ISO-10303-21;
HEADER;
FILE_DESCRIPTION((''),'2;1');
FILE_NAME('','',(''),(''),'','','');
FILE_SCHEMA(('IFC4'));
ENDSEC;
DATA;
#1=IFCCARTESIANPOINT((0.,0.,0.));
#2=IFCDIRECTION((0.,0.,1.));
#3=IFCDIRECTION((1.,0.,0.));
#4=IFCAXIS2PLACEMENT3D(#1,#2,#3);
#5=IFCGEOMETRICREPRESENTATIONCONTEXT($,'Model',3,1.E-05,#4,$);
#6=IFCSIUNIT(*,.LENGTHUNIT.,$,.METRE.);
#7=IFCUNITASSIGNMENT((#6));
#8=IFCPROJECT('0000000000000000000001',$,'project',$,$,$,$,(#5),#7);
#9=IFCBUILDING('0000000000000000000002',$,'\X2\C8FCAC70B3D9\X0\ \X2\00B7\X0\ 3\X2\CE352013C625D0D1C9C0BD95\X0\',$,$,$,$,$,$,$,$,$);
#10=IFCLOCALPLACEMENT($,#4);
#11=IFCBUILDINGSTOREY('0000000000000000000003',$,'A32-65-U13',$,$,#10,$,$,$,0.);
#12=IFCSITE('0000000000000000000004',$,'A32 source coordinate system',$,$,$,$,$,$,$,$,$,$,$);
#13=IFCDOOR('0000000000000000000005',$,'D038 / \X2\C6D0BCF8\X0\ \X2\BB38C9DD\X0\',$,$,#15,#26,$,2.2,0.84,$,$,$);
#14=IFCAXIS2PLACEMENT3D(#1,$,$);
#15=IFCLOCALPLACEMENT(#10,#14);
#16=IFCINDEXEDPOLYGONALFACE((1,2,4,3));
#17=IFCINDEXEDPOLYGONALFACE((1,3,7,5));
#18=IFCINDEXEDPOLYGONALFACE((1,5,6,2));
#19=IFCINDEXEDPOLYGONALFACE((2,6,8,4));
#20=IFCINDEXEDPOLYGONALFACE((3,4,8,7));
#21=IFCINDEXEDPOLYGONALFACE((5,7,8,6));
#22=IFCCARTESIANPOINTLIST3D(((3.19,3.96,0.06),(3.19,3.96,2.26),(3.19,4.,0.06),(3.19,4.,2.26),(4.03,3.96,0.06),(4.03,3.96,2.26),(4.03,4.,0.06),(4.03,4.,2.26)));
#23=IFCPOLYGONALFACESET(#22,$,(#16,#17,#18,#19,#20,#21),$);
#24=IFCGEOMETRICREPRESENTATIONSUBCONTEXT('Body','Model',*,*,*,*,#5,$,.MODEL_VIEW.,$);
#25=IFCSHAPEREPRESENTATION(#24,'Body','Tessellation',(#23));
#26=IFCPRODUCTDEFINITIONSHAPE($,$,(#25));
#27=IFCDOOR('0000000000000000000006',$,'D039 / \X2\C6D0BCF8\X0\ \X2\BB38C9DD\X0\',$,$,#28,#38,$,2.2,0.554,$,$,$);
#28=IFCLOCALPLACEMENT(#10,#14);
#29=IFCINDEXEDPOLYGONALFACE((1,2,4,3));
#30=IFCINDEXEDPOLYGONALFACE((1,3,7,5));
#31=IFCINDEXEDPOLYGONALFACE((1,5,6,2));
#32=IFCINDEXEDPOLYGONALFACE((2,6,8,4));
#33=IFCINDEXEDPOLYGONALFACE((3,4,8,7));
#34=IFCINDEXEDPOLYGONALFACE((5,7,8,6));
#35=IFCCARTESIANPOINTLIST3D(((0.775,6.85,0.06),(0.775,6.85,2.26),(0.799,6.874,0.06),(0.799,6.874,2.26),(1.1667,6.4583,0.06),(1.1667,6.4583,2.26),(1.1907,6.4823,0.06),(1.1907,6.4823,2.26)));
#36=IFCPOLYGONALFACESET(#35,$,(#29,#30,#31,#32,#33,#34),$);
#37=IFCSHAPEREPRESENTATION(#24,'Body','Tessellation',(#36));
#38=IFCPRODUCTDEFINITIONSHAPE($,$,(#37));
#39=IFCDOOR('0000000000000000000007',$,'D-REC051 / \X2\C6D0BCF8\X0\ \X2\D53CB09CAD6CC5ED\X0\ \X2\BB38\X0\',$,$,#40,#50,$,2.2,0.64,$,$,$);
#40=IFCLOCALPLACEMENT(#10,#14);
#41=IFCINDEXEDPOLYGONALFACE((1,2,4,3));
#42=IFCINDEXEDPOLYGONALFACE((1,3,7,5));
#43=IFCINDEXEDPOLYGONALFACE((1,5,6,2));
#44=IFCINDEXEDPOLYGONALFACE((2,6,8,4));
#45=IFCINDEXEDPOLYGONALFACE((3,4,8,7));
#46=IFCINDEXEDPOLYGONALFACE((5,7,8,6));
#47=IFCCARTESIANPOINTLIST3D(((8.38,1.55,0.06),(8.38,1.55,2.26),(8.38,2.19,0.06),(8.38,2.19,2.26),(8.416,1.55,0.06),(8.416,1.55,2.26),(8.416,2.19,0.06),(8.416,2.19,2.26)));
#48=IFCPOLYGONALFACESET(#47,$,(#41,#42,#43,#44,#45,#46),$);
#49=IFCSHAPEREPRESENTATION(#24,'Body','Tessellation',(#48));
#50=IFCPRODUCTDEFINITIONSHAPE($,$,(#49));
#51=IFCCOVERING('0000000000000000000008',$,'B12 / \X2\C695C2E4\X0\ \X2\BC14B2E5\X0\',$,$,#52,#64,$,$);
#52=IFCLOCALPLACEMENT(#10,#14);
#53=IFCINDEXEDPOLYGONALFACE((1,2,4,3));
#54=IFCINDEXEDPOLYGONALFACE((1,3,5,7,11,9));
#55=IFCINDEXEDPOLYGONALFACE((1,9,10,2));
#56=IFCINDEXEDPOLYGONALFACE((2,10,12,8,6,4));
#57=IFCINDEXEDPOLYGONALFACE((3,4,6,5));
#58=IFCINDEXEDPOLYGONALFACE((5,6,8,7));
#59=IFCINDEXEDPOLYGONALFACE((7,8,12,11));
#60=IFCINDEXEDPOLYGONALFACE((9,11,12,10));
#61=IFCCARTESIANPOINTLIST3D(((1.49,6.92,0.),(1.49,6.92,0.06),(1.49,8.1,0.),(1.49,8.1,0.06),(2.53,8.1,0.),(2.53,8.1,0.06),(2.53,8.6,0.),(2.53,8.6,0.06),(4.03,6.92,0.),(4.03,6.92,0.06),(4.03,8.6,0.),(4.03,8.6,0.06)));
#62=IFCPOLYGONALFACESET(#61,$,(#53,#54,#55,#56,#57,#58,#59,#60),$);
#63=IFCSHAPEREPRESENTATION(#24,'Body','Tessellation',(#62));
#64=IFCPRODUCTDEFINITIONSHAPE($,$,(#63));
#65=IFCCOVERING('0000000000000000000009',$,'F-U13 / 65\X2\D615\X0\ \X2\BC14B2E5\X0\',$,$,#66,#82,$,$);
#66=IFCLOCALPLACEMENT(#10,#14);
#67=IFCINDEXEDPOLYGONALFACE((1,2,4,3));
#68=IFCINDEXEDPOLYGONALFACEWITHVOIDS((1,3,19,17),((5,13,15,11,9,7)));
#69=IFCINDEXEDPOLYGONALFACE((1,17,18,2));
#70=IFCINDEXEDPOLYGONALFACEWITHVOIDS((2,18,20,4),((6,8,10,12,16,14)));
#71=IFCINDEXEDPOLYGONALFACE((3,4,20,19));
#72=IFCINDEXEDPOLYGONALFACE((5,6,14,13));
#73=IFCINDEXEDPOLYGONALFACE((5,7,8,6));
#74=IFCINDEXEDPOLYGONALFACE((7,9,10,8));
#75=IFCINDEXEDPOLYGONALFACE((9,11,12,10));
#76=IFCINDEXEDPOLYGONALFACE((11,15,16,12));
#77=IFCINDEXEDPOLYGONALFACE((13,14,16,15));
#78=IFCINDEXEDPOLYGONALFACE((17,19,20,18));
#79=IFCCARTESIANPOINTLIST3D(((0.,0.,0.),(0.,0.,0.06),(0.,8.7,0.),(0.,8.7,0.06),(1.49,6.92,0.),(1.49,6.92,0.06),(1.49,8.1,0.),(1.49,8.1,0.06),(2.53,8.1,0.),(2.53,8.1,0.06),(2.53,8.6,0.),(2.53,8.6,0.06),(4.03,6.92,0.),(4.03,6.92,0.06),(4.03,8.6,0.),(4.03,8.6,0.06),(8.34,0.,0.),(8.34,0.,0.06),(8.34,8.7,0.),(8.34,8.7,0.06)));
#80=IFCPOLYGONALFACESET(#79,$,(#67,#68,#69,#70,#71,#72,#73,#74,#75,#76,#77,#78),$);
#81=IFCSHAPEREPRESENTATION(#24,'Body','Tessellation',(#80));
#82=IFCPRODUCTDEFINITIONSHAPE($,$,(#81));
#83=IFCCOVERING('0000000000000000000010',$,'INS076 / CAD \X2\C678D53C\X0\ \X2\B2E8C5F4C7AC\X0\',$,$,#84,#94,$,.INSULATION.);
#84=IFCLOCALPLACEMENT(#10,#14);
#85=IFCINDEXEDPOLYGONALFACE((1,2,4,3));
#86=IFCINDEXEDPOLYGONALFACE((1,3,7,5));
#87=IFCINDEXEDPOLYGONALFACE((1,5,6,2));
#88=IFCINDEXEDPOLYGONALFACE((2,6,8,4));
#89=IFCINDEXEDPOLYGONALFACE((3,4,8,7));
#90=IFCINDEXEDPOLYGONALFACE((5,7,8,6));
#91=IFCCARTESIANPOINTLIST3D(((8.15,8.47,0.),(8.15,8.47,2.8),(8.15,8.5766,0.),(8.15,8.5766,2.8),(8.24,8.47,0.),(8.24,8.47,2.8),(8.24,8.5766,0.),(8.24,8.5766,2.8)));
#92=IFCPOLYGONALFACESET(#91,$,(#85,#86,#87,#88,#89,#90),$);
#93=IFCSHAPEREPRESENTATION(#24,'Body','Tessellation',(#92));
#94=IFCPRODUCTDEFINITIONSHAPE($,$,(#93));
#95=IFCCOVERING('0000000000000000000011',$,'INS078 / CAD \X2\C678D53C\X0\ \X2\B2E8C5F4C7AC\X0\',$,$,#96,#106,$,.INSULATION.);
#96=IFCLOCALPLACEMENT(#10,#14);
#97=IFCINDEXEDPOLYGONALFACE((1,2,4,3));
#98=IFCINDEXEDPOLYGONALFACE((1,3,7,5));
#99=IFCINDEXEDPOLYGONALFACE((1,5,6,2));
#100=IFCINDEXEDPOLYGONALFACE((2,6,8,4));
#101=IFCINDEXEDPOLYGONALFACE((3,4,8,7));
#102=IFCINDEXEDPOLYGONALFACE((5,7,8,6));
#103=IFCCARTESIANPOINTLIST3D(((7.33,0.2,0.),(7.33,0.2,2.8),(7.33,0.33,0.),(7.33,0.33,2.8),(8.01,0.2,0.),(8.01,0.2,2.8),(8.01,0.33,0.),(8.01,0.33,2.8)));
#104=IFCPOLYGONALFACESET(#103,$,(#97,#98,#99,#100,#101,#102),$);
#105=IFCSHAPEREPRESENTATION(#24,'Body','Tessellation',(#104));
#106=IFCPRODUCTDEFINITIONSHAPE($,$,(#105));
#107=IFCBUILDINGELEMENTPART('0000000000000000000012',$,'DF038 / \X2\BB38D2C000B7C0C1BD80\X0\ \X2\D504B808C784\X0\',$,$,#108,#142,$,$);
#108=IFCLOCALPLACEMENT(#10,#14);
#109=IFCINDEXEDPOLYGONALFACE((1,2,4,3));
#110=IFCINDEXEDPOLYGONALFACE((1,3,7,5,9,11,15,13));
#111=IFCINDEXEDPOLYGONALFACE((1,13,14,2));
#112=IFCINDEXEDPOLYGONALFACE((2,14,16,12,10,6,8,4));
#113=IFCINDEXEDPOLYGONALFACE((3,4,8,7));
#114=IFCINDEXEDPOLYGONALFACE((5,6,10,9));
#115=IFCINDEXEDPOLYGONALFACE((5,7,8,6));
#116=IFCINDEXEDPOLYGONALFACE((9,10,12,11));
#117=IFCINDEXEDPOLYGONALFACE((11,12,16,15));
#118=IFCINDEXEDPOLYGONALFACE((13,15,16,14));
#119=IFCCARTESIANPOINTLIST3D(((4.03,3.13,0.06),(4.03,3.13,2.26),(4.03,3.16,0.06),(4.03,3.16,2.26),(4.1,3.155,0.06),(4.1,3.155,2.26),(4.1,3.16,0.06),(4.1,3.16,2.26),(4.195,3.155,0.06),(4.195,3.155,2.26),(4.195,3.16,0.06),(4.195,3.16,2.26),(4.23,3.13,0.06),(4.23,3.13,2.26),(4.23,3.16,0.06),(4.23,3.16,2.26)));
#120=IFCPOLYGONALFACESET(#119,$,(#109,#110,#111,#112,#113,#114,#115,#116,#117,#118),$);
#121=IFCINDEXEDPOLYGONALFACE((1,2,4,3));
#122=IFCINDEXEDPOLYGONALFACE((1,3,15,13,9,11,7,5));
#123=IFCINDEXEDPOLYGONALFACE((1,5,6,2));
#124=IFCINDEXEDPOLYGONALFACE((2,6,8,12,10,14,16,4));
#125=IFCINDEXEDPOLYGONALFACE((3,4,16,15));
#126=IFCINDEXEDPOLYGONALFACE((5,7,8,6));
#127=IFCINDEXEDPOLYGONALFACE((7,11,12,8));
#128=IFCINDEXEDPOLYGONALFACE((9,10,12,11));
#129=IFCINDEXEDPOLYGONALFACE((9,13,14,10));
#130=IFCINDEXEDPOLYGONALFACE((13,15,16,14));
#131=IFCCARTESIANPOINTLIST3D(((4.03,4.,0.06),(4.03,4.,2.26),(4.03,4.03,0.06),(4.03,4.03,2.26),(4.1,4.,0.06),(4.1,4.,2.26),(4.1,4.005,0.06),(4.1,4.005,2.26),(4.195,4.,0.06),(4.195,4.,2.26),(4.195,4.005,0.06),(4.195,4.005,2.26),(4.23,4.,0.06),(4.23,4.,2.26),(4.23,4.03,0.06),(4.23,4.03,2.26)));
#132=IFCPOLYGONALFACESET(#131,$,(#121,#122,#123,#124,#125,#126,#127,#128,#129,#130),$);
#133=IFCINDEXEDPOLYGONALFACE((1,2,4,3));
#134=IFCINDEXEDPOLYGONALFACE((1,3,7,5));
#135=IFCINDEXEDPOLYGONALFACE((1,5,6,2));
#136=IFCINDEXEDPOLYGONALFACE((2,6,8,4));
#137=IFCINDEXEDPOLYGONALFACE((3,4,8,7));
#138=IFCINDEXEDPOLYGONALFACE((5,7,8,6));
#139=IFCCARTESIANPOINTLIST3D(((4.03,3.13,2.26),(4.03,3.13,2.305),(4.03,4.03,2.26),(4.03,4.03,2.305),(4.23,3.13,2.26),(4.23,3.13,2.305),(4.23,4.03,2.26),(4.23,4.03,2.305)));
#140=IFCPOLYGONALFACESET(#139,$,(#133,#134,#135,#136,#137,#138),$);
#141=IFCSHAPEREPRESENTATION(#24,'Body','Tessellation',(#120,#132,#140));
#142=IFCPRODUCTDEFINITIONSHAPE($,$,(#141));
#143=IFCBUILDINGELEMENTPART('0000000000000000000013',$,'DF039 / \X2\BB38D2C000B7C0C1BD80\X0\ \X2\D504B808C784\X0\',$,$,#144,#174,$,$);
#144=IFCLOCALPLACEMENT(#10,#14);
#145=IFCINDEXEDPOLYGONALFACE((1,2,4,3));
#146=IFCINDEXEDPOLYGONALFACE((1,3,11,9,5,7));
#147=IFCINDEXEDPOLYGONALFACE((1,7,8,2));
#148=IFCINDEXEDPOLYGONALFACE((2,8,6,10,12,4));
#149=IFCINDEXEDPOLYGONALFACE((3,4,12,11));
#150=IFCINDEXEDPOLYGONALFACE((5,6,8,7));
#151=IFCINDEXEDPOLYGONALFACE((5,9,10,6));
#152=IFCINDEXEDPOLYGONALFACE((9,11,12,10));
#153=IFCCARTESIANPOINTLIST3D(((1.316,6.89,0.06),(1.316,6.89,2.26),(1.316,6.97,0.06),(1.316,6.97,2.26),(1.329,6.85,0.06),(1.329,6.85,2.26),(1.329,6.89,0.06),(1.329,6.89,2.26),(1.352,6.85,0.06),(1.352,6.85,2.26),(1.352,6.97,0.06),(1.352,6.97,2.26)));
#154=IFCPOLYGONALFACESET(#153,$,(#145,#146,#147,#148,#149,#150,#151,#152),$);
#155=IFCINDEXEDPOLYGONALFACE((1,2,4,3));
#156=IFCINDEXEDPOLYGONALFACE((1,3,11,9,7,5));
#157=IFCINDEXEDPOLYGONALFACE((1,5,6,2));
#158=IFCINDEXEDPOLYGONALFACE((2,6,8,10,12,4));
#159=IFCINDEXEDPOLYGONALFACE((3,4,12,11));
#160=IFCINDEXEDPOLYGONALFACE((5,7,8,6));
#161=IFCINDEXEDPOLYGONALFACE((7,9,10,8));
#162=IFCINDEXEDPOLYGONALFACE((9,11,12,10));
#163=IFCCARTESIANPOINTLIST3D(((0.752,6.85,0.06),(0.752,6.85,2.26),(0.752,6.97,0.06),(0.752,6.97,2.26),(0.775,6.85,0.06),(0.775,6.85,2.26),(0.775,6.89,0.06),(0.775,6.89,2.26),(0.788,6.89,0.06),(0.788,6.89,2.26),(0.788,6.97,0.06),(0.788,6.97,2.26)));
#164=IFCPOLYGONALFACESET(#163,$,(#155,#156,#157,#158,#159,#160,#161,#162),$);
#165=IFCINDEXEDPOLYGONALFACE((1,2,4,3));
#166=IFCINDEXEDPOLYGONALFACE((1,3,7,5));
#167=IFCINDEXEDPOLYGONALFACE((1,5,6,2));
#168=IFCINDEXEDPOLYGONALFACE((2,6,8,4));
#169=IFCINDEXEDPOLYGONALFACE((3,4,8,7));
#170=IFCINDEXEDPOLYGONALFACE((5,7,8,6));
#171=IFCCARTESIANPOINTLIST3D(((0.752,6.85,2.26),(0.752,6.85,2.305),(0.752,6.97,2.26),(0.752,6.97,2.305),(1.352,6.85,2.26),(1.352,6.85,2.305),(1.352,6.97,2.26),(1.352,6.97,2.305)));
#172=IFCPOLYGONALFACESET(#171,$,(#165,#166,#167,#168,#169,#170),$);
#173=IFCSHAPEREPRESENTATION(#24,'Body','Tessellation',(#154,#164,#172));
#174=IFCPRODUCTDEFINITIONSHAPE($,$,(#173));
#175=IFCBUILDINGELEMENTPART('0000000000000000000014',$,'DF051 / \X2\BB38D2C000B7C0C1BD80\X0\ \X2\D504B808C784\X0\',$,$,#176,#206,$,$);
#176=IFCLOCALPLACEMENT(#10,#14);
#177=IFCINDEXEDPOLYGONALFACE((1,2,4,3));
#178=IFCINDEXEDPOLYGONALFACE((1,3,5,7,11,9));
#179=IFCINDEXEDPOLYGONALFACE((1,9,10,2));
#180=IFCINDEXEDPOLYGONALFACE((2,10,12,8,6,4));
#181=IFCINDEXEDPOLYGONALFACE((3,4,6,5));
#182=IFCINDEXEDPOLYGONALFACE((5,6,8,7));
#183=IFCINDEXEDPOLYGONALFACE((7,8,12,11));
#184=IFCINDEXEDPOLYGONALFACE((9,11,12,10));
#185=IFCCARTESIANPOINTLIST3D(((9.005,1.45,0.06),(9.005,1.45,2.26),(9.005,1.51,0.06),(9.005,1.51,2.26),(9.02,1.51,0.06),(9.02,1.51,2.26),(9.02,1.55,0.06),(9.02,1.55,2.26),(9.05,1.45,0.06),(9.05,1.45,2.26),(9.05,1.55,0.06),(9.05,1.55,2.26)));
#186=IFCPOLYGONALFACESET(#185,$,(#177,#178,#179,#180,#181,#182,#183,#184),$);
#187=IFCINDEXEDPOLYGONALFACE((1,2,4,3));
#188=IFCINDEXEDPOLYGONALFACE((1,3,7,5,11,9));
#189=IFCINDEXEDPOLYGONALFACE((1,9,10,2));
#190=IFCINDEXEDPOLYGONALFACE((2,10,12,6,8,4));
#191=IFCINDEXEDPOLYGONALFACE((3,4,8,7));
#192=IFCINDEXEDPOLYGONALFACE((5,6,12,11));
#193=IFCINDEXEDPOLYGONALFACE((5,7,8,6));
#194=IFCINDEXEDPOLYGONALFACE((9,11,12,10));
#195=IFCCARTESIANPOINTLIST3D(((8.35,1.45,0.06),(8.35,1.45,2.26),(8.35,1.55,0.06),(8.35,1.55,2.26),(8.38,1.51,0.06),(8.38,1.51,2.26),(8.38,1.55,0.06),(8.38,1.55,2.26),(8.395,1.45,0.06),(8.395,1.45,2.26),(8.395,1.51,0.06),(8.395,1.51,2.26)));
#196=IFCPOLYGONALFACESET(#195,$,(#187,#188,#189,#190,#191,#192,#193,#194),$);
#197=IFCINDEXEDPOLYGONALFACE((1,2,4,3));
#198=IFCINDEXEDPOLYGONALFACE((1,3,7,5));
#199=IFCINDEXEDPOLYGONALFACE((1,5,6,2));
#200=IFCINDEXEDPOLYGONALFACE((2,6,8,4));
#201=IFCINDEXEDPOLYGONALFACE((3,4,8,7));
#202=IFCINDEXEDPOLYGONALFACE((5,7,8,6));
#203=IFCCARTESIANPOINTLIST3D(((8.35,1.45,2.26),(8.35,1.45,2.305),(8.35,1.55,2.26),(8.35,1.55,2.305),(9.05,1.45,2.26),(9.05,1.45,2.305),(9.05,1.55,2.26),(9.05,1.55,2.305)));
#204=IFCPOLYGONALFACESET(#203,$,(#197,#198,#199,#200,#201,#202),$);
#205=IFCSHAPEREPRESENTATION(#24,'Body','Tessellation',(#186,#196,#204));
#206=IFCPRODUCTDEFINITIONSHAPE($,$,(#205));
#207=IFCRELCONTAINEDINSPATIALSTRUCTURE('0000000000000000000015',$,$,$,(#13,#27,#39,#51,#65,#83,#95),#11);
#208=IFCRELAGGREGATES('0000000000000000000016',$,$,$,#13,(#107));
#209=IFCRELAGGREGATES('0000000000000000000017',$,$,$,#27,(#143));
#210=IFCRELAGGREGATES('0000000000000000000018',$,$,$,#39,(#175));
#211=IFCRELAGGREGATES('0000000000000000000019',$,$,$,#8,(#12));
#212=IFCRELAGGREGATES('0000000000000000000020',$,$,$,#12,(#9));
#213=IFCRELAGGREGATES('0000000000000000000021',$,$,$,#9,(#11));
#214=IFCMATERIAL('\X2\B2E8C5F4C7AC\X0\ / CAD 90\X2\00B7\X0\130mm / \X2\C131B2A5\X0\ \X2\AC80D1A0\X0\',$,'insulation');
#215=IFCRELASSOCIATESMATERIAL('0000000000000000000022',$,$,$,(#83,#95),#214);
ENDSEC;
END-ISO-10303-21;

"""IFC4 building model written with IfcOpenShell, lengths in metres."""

from ifc_helpers import new_model, si_unit, frame, origin, origin_with_axes, place, context, subcontext, project, spatial, polyline, outline, extrude, material, element, aggregate, save


model = new_model("IFC4")

# Units and contexts
model_context = context("Model", 3, precision=1e-05, world=origin_with_axes())
body_context = subcontext(model_context, "Body", "Model", "MODEL_VIEW")
ifc_project = project(units=[si_unit("LENGTHUNIT", "METRE")], contexts=[model_context])

# Site, building, storey
storey_placement = place(None, origin_with_axes())
site = spatial("IfcSite", under=ifc_project, Name="A32 source coordinate system")
building = spatial("IfcBuilding", under=site, Name="주거동 · 3층–옥탑지붕")
storey = spatial("IfcBuildingStorey", under=building, at=storey_placement, Name="A32-65-U13", Elevation=0.0)

# Doors
door_1_placement = place(storey_placement, origin_with_axes())
door_1 = element("IfcDoor", 1, at=door_1_placement, inside=storey, Name="D038 / 원본 문짝", OverallHeight=2.2, OverallWidth=0.84, context=body_context, shape_type="SweptSolid", body=[
    extrude(outline(polyline([(3.19, 3.96), (3.19, 4.0), (4.03, 4.0), (4.03, 3.96), (3.19, 3.96)])), frame((0.0, 0.0, 0.06)), (0.0, 0.0, 1.0), 2.2),
])
door_2_placement = place(storey_placement, origin_with_axes())
door_2 = element("IfcDoor", 2, at=door_2_placement, inside=storey, Name="D039 / 원본 문짝", OverallHeight=2.2, OverallWidth=0.554, context=body_context, shape_type="SweptSolid", body=[
    extrude(outline(polyline([(1.1907, 6.4823), (1.1667, 6.4583), (0.775, 6.85), (0.799, 6.874), (1.1907, 6.4823)])), frame((0.0, 0.0, 0.06)), (0.0, 0.0, 1.0), 2.2),
])
door_3_placement = place(storey_placement, origin_with_axes())
door_3 = element("IfcDoor", 3, at=door_3_placement, inside=storey, Name="D-REC051 / 원본 피난구역 문", OverallHeight=2.2, OverallWidth=0.64, context=body_context, shape_type="SweptSolid", body=[
    extrude(outline(polyline([(8.416, 2.19), (8.416, 1.55), (8.38, 1.55), (8.38, 2.19), (8.416, 2.19)])), frame((0.0, 0.0, 0.06)), (0.0, 0.0, 1.0), 2.2),
])

# Coverings
covering_1_placement = place(storey_placement, origin_with_axes())
element("IfcCovering", 4, at=covering_1_placement, inside=storey, Name="B12 / 욕실 바닥", context=body_context, shape_type="SweptSolid", body=[
    extrude(outline(polyline([(2.53, 8.6), (4.03, 8.6), (4.03, 6.92), (1.49, 6.92), (1.49, 8.1), (2.53, 8.1), (2.53, 8.6)])), origin(), (0.0, 0.0, 1.0), 0.06),
])
covering_2_placement = place(storey_placement, origin_with_axes())
element("IfcCovering", 5, at=covering_2_placement, inside=storey, Name="F-U13 / 65형 바닥", context=body_context, shape_type="SweptSolid", body=[
    extrude(outline(polyline([(0.0, 0.0), (0.0, 8.7), (8.34, 8.7), (8.34, 0.0), (0.0, 0.0)]), holes=[polyline([(2.53, 8.1), (1.49, 8.1), (1.49, 6.92), (4.03, 6.92), (4.03, 8.6), (2.53, 8.6), (2.53, 8.1)])]), origin(), (0.0, 0.0, 1.0), 0.06),
])
ifc_material = material(Name="단열재 / CAD 90·130mm / 성능 검토", Category="insulation")
covering_3_placement = place(storey_placement, origin_with_axes())
element("IfcCovering", 6, at=covering_3_placement, inside=storey, material=ifc_material, Name="INS076 / CAD 외피 단열재", PredefinedType="INSULATION", context=body_context, shape_type="SweptSolid", body=[
    extrude(outline(polyline([(8.24, 8.5766), (8.24, 8.47), (8.15, 8.47), (8.15, 8.5766), (8.24, 8.5766)])), origin(), (0.0, 0.0, 1.0), 2.8),
])
covering_4_placement = place(storey_placement, origin_with_axes())
element("IfcCovering", 7, at=covering_4_placement, inside=storey, material=ifc_material, Name="INS078 / CAD 외피 단열재", PredefinedType="INSULATION", context=body_context, shape_type="SweptSolid", body=[
    extrude(outline(polyline([(8.01, 0.2), (7.33, 0.2), (7.33, 0.33), (8.01, 0.33), (8.01, 0.2)])), origin(), (0.0, 0.0, 1.0), 2.8),
])

# Building element parts
building_element_part_1_placement = place(door_1_placement, origin_with_axes())
building_element_part_1 = element("IfcBuildingElementPart", 8, at=building_element_part_1_placement, Name="DF038 / 문틀·상부 프레임", context=body_context, shape_type="SweptSolid", body=[
    extrude(outline(polyline([(4.03, 3.16), (4.1, 3.16), (4.1, 3.155), (4.195, 3.155), (4.195, 3.16), (4.23, 3.16), (4.23, 3.13), (4.03, 3.13), (4.03, 3.16)])), frame((0.0, 0.0, 0.06)), (0.0, 0.0, 1.0), 2.2),
    extrude(outline(polyline([(4.23, 4.03), (4.23, 4.0), (4.195, 4.0), (4.195, 4.005), (4.1, 4.005), (4.1, 4.0), (4.03, 4.0), (4.03, 4.03), (4.23, 4.03)])), frame((0.0, 0.0, 0.06)), (0.0, 0.0, 1.0), 2.2),
    extrude(outline(polyline([(4.03, 3.13), (4.03, 4.03), (4.23, 4.03), (4.23, 3.13), (4.03, 3.13)])), frame((0.0, 0.0, 2.26)), (0.0, 0.0, 1.0), 0.045),
])
aggregate(door_1, [building_element_part_1])
building_element_part_2_placement = place(door_2_placement, origin_with_axes())
building_element_part_2 = element("IfcBuildingElementPart", 9, at=building_element_part_2_placement, Name="DF039 / 문틀·상부 프레임", context=body_context, shape_type="SweptSolid", body=[
    extrude(outline(polyline([(1.352, 6.85), (1.329, 6.85), (1.329, 6.89), (1.316, 6.89), (1.316, 6.97), (1.352, 6.97), (1.352, 6.85)])), frame((0.0, 0.0, 0.06)), (0.0, 0.0, 1.0), 2.2),
    extrude(outline(polyline([(0.788, 6.97), (0.788, 6.89), (0.775, 6.89), (0.775, 6.85), (0.752, 6.85), (0.752, 6.97), (0.788, 6.97)])), frame((0.0, 0.0, 0.06)), (0.0, 0.0, 1.0), 2.2),
    extrude(outline(polyline([(0.752, 6.85), (0.752, 6.97), (1.352, 6.97), (1.352, 6.85), (0.752, 6.85)])), frame((0.0, 0.0, 2.26)), (0.0, 0.0, 1.0), 0.045),
])
aggregate(door_2, [building_element_part_2])
building_element_part_3_placement = place(door_3_placement, origin_with_axes())
building_element_part_3 = element("IfcBuildingElementPart", 10, at=building_element_part_3_placement, Name="DF051 / 문틀·상부 프레임", context=body_context, shape_type="SweptSolid", body=[
    extrude(outline(polyline([(9.05, 1.45), (9.005, 1.45), (9.005, 1.51), (9.02, 1.51), (9.02, 1.55), (9.05, 1.55), (9.05, 1.45)])), frame((0.0, 0.0, 0.06)), (0.0, 0.0, 1.0), 2.2),
    extrude(outline(polyline([(8.38, 1.55), (8.38, 1.51), (8.395, 1.51), (8.395, 1.45), (8.35, 1.45), (8.35, 1.55), (8.38, 1.55)])), frame((0.0, 0.0, 0.06)), (0.0, 0.0, 1.0), 2.2),
    extrude(outline(polyline([(8.35, 1.45), (8.35, 1.55), (9.05, 1.55), (9.05, 1.45), (8.35, 1.45)])), frame((0.0, 0.0, 2.26)), (0.0, 0.0, 1.0), 0.045),
])
aggregate(door_3, [building_element_part_3])

save(model, "model.ifc")
